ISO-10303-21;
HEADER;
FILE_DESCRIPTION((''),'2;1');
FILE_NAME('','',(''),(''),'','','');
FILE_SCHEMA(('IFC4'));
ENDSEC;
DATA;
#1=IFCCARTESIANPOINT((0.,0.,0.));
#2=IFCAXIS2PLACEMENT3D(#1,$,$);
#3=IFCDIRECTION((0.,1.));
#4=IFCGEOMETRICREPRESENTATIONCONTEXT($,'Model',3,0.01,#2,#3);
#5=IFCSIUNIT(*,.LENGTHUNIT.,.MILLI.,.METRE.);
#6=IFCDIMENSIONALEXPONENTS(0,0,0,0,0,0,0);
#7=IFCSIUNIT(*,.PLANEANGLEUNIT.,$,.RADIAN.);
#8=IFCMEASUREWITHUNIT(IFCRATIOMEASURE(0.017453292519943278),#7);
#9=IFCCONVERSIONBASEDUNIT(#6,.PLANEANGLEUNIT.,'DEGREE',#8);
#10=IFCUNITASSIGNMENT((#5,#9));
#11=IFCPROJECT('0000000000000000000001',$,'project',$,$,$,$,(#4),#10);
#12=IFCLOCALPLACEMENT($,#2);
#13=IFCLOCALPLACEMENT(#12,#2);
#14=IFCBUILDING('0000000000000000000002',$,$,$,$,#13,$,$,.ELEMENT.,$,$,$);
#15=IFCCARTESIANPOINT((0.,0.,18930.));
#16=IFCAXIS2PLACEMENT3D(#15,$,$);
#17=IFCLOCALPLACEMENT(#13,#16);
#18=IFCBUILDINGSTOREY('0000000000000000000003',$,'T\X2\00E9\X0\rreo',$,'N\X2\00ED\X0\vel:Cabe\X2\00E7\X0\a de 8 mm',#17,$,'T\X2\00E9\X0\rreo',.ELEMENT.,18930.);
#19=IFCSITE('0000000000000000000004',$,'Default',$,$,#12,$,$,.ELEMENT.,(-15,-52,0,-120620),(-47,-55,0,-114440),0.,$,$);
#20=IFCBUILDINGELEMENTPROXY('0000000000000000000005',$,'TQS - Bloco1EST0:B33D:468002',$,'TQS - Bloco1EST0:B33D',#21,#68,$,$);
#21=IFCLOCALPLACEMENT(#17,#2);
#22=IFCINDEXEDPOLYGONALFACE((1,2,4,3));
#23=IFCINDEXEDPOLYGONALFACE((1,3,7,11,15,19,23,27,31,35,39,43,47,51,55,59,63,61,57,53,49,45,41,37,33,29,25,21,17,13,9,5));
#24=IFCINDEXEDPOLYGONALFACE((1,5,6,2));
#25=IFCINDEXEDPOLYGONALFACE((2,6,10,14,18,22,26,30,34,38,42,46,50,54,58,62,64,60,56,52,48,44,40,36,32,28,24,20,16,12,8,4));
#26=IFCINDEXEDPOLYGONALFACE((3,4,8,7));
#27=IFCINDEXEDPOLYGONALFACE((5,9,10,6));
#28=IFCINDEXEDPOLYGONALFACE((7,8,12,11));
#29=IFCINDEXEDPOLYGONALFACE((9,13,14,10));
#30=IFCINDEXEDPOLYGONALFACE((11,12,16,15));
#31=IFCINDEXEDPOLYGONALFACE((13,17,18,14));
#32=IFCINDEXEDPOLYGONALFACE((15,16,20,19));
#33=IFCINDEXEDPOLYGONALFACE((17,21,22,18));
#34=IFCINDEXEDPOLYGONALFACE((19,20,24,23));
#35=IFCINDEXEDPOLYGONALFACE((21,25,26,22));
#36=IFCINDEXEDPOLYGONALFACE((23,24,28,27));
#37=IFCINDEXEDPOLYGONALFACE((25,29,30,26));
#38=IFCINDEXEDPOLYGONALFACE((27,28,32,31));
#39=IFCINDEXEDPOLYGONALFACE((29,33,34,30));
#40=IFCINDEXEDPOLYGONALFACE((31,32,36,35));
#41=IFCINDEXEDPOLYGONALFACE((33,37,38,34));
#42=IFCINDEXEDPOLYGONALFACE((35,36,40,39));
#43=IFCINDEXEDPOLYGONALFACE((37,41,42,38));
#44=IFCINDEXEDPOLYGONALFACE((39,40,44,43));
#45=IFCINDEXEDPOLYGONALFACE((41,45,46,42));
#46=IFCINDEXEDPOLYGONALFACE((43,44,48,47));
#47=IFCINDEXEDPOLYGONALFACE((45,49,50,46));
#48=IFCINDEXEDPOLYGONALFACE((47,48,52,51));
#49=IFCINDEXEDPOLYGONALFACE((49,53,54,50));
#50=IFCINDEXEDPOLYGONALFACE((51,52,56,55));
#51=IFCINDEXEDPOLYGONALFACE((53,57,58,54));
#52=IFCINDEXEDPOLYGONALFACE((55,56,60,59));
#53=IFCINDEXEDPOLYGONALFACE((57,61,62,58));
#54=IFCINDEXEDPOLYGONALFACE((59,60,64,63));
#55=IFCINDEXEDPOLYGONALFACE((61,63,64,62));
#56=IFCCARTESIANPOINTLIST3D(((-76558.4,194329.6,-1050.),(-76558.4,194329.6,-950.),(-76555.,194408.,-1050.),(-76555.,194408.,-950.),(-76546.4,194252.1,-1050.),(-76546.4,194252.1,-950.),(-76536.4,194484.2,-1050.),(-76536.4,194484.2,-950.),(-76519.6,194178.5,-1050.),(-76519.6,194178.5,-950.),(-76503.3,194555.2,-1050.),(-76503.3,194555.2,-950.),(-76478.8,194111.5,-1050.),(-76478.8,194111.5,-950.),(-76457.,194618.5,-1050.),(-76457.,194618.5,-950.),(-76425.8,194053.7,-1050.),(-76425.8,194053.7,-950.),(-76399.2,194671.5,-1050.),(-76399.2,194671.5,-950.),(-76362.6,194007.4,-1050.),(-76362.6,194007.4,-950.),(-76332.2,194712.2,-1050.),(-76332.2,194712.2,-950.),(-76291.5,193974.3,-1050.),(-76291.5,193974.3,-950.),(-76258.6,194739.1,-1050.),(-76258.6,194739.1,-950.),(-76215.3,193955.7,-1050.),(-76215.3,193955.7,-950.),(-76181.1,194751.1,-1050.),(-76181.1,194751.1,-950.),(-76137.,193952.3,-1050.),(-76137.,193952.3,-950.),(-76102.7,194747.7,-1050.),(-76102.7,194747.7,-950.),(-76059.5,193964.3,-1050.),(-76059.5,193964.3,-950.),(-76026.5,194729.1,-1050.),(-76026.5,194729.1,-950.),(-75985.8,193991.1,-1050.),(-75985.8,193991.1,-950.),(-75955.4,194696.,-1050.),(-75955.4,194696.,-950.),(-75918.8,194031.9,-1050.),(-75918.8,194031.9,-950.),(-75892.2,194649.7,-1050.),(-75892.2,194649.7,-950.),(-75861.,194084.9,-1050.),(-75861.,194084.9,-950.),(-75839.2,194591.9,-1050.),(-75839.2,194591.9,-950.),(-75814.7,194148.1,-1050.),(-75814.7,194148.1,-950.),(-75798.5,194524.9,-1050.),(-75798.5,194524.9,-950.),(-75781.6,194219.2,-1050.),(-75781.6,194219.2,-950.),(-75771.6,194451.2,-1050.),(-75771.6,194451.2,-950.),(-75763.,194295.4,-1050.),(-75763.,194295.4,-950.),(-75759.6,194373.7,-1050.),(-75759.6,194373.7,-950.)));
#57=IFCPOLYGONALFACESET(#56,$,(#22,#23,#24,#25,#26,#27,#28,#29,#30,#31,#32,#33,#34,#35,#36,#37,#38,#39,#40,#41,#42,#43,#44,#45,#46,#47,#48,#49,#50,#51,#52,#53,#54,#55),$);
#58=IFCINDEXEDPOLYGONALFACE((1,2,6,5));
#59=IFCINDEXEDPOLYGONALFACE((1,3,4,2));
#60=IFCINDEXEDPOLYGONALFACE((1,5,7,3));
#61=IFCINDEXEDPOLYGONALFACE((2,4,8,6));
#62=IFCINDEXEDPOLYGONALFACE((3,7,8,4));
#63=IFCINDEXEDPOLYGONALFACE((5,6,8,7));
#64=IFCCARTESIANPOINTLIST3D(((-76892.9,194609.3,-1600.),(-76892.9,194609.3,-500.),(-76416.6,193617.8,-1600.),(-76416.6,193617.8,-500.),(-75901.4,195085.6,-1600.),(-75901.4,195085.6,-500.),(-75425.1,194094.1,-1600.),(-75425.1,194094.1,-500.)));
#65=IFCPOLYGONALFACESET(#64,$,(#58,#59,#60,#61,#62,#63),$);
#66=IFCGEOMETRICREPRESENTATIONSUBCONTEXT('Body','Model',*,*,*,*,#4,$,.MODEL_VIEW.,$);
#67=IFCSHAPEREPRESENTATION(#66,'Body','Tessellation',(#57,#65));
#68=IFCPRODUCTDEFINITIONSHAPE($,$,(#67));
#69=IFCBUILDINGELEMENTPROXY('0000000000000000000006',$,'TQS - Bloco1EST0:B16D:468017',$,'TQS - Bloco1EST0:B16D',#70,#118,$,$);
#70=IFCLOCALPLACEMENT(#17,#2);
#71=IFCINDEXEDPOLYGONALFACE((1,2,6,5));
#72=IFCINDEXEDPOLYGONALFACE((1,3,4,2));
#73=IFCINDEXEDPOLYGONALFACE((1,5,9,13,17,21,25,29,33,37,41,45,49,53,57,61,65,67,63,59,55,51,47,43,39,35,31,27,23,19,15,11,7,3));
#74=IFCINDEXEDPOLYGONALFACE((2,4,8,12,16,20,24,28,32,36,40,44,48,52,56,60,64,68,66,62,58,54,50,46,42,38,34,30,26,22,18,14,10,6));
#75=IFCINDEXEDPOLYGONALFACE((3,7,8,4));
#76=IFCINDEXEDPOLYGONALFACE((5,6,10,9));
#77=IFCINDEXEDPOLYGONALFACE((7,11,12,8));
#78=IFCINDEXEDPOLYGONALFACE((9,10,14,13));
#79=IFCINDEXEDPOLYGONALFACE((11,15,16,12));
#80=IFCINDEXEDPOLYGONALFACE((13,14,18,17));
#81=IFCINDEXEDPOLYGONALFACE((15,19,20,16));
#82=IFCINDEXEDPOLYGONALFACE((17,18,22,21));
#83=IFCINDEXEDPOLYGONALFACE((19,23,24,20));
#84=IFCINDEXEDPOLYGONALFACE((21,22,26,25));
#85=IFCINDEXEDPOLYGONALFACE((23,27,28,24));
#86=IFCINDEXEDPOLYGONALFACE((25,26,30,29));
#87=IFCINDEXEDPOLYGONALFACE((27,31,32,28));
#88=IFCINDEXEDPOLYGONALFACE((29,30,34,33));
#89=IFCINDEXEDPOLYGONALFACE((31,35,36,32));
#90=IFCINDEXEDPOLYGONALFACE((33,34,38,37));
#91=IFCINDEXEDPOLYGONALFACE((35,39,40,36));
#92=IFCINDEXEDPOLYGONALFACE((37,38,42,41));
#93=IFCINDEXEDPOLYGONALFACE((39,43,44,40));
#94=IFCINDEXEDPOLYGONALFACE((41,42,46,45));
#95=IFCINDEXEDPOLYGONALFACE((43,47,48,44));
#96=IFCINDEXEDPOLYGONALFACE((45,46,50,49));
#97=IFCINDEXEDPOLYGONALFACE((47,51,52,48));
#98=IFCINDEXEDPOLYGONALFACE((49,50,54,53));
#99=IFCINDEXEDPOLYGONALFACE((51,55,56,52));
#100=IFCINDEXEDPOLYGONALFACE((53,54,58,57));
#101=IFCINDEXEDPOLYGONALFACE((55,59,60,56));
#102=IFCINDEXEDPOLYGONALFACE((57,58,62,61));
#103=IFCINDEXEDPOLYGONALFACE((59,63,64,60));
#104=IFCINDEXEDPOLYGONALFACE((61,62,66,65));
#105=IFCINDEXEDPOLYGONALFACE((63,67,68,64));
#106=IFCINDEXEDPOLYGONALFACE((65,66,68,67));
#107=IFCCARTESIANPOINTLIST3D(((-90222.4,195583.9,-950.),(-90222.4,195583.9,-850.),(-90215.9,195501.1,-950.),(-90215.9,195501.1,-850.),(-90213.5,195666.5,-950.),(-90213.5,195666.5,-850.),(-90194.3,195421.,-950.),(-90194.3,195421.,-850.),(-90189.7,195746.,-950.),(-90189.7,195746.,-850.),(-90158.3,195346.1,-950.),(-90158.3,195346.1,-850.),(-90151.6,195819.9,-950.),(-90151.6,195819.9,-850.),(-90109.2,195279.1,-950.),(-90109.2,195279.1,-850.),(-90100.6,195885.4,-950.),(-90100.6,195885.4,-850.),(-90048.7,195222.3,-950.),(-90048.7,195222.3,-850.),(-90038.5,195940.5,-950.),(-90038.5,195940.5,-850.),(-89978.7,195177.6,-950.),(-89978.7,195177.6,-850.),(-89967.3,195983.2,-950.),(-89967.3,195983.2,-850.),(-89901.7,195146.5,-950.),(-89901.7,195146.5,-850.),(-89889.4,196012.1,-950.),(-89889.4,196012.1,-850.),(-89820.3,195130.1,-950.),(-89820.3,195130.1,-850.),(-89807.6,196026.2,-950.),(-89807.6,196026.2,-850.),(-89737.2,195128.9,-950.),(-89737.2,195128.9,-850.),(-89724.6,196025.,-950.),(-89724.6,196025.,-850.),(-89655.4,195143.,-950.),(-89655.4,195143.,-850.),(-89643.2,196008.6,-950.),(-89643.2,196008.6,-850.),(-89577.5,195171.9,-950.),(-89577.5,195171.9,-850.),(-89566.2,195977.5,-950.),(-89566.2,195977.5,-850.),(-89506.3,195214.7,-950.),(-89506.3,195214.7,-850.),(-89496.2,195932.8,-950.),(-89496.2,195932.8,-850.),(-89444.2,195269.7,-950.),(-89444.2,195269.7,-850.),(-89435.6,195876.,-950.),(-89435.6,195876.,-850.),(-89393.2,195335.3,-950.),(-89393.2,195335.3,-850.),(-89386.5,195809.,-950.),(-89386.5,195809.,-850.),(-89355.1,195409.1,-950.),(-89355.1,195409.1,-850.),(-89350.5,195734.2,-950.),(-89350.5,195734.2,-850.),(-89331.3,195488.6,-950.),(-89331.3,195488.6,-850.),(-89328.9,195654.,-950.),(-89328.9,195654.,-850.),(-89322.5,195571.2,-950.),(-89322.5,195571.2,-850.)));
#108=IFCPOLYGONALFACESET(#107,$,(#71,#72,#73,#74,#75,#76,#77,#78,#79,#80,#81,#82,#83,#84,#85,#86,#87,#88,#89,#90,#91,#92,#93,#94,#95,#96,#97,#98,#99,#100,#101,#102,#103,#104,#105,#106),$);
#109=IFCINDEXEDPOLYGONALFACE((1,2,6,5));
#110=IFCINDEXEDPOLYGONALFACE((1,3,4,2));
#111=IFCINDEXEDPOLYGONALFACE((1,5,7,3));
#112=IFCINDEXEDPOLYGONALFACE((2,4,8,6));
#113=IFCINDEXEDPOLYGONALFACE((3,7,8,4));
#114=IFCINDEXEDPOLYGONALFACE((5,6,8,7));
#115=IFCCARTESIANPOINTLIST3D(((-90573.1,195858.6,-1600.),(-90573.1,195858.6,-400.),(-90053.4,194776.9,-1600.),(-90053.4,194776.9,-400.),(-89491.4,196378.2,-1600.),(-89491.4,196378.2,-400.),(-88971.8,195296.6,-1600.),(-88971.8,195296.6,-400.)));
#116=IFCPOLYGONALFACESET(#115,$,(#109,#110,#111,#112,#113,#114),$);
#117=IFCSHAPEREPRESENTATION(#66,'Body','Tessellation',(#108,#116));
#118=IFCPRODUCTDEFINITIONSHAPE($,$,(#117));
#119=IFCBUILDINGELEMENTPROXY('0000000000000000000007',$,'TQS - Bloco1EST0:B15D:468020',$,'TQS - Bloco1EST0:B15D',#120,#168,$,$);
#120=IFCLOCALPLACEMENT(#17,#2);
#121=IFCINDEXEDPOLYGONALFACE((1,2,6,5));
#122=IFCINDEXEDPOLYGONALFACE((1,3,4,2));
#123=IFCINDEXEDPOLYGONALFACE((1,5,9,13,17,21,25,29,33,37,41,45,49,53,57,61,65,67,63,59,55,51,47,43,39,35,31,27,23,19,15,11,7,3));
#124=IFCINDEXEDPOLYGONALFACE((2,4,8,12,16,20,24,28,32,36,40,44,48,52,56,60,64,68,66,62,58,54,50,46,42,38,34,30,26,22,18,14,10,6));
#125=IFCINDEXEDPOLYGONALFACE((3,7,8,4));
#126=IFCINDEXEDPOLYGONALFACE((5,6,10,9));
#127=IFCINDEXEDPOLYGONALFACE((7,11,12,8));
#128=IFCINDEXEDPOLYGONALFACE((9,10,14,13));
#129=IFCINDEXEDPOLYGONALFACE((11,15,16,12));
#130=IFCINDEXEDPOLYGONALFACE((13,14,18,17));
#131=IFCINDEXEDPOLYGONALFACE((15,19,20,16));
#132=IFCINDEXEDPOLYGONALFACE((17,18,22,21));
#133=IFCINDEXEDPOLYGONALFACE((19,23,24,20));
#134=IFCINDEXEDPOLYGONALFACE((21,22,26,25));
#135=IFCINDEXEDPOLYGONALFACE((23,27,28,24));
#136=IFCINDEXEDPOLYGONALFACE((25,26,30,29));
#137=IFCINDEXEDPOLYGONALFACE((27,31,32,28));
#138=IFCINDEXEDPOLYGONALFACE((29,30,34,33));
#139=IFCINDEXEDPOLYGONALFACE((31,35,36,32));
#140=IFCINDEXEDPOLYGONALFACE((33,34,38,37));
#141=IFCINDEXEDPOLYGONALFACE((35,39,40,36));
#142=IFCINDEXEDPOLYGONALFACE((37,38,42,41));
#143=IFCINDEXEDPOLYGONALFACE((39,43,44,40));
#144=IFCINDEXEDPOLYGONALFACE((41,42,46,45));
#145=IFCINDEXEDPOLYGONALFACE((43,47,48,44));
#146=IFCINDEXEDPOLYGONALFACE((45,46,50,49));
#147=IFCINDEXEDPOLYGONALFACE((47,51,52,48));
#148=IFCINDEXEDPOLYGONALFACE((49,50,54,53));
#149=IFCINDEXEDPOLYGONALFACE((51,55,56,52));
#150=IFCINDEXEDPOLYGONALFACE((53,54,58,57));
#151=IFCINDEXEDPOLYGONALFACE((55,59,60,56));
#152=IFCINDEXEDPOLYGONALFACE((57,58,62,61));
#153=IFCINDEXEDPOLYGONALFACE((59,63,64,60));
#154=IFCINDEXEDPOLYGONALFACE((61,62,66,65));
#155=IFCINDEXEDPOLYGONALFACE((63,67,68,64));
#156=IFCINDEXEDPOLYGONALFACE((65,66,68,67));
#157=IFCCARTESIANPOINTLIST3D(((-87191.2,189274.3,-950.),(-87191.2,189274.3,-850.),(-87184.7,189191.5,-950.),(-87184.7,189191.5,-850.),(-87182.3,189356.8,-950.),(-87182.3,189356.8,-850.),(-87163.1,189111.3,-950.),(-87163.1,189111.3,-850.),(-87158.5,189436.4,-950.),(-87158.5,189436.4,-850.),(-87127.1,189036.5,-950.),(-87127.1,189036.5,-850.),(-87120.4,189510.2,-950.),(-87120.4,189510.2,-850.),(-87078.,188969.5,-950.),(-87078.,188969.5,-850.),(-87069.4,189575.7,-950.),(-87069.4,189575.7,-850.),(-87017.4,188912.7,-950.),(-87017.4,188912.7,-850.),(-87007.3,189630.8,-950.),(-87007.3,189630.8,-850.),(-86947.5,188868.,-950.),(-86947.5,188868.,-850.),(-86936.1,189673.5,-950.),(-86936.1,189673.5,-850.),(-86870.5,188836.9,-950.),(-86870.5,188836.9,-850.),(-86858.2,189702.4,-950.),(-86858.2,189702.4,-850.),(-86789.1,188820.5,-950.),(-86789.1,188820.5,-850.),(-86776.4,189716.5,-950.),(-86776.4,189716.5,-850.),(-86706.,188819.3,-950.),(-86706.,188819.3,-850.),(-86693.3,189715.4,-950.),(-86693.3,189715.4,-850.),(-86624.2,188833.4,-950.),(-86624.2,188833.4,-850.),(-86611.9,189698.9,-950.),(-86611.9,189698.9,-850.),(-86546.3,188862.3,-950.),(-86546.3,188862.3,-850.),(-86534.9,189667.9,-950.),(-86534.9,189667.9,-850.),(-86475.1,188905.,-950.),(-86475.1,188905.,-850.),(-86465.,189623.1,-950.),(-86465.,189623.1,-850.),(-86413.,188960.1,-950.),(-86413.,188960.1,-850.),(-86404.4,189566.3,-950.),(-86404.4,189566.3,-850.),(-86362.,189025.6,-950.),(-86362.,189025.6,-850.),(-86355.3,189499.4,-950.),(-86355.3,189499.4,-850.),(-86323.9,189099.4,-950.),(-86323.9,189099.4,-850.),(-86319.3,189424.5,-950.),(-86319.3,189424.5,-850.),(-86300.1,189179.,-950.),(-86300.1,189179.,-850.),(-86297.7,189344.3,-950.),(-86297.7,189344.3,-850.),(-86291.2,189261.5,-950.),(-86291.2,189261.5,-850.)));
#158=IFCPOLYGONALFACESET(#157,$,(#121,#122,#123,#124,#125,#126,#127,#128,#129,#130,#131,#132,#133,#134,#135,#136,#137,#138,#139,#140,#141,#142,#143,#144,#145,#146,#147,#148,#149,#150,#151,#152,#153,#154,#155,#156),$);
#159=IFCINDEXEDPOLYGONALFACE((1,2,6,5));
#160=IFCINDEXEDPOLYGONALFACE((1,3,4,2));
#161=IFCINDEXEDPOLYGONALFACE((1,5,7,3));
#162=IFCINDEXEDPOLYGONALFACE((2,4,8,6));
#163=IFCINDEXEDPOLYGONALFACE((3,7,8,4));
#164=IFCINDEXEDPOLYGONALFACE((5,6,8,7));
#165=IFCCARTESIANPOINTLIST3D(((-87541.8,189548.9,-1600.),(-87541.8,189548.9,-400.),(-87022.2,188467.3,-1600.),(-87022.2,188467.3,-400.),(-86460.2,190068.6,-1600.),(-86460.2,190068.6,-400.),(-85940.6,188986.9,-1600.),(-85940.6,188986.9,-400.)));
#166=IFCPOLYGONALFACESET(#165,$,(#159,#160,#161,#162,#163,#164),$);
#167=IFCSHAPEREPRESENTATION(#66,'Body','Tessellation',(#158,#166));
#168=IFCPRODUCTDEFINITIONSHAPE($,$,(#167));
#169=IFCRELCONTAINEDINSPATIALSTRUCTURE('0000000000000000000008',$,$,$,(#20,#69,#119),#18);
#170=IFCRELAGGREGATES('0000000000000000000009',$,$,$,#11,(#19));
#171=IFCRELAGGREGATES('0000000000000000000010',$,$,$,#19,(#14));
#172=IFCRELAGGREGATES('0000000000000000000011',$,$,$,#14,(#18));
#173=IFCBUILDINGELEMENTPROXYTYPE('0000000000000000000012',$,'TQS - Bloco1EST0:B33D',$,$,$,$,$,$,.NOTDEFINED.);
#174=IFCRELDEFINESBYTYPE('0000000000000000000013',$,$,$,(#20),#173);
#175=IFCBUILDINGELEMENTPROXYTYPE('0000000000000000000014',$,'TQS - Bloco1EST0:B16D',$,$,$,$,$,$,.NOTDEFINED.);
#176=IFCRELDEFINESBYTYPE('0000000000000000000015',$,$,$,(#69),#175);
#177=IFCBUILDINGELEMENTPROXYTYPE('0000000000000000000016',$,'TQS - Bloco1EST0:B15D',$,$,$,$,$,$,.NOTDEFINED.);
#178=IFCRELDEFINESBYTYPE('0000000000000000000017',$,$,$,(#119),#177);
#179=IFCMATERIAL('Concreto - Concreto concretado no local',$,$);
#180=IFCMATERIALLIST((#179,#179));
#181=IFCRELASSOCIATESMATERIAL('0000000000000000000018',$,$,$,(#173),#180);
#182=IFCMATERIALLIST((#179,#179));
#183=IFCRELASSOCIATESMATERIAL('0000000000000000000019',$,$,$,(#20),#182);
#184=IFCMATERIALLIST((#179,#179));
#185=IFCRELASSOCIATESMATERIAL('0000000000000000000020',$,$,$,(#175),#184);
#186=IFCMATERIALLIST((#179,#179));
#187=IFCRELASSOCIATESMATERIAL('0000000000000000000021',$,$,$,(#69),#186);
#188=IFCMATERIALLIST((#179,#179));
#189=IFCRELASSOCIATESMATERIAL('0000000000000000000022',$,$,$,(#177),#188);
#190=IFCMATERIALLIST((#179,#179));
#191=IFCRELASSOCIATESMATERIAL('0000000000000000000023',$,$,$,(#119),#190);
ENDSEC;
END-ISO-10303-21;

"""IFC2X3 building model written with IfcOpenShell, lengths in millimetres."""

from ifc_helpers import new_model, entity, si_unit, converted_unit, direction, frame, frame_2d, origin, origin_2d_with_axis, place, context, subcontext, project, spatial, rectangle, circle, extrude, source, transform, mapped, material, material_list, type_object, type_shapes, element, save


model = new_model("IFC2X3")

# Units and contexts
model_context = context("Model", 3, precision=0.01, world=origin(), true_north=direction((0.0, 1.0)))
body_context = subcontext(model_context, "Body", "Model", "MODEL_VIEW")
ifc_project = project(units=[si_unit("LENGTHUNIT", "METRE", prefix="MILLI"), converted_unit("PLANEANGLEUNIT", "DEGREE", entity("IfcRatioMeasure", 0.017453292519943278), si_unit("PLANEANGLEUNIT", "RADIAN"), dimensions=[0, 0, 0, 0, 0, 0, 0])], contexts=[model_context])

# Site, building, storey
site_placement = place(None, origin())
site = spatial("IfcSite", under=ifc_project, at=site_placement, Name="Default", CompositionType="ELEMENT", RefLatitude=(-15, -52, 0, -120620), RefLongitude=(-47, -55, 0, -114440), RefElevation=0.0)
building_placement = place(site_placement, origin())
building = spatial("IfcBuilding", under=site, at=building_placement, CompositionType="ELEMENT")
storey_placement = place(building_placement, frame((0.0, 0.0, 18930.0)))
storey = spatial("IfcBuildingStorey", under=building, at=storey_placement, Name="Térreo", ObjectType="Nível:Cabeça de 8 mm", LongName="Térreo", CompositionType="ELEMENT", Elevation=18930.0)

# Building element proxies
ifc_material_1 = material(Name="Concreto - Concreto concretado no local")
ifc_material_list_1 = material_list([ifc_material_1, ifc_material_1])
ifc_material_list_2 = material_list([ifc_material_1, ifc_material_1])
building_element_proxy_type_1 = type_object("IfcBuildingElementProxyType", Name="TQS - Bloco1EST0:B33D", PredefinedType="NOTDEFINED", material=ifc_material_list_2)
shared_shape_1 = source(origin(), body_context, "Body", "SweptSolid", [
    extrude(circle(Radius=400.0, at=frame_2d((0.0, 0.0), x_axis=(1.0, 0.0))), frame((0.0, 0.0, -550.0)), (0.0, 0.0, 1.0), 100.0),
    extrude(rectangle(XDim=1100.0, YDim=1100.0, at=origin_2d_with_axis()), frame((0.0, 0.0, -1100.0), z_axis=(0.0, 0.0, 1.0), x_axis=(-1.0, 0.0, 0.0)), (0.0, 0.0, 1.0), 1100.0),
])
type_shapes(building_element_proxy_type_1, [shared_shape_1])
proxy_1_placement = place(storey_placement, frame((-76159.0, 194351.7, -500.0), z_axis=(0.0, 0.0, 1.0), x_axis=(-0.43303, 0.90138, 0.0)))
element("IfcBuildingElementProxy", 1, at=proxy_1_placement, inside=storey, type_object=building_element_proxy_type_1, material=ifc_material_list_1, Name="TQS - Bloco1EST0:B33D:468002", ObjectType="TQS - Bloco1EST0:B33D", context=body_context, shape_type="MappedRepresentation", body=[
    mapped(shared_shape_1, transform((0.0, 0.0, 0.0), scale=1.0)),
])
ifc_material_list_3 = material_list([ifc_material_1, ifc_material_1])
ifc_material_list_4 = material_list([ifc_material_1, ifc_material_1])
building_element_proxy_type_2 = type_object("IfcBuildingElementProxyType", Name="TQS - Bloco1EST0:B16D", PredefinedType="NOTDEFINED", material=ifc_material_list_4)
shared_shape_2 = source(origin(), body_context, "Body", "SweptSolid", [
    extrude(circle(Radius=450.0, at=frame_2d((0.0, 0.0), x_axis=(1.0, 0.0))), frame((0.0, 0.0, -550.0)), (0.0, 0.0, 1.0), 100.0),
    extrude(rectangle(XDim=1200.0, YDim=1200.0, at=origin_2d_with_axis()), frame((0.0, 0.0, -1200.0), z_axis=(0.0, 0.0, 1.0), x_axis=(-1.0, 0.0, 0.0)), (0.0, 0.0, 1.0), 1200.0),
])
type_shapes(building_element_proxy_type_2, [shared_shape_2])
proxy_2_placement = place(storey_placement, frame((-89772.4, 195577.6, -400.0), z_axis=(0.0, 0.0, 1.0), x_axis=(-0.43303, 0.90138, 0.0)))
element("IfcBuildingElementProxy", 2, at=proxy_2_placement, inside=storey, type_object=building_element_proxy_type_2, material=ifc_material_list_3, Name="TQS - Bloco1EST0:B16D:468017", ObjectType="TQS - Bloco1EST0:B16D", context=body_context, shape_type="MappedRepresentation", body=[
    mapped(shared_shape_2, transform((0.0, 0.0, 0.0), scale=1.0)),
])
ifc_material_list_5 = material_list([ifc_material_1, ifc_material_1])
ifc_material_list_6 = material_list([ifc_material_1, ifc_material_1])
building_element_proxy_type_3 = type_object("IfcBuildingElementProxyType", Name="TQS - Bloco1EST0:B15D", PredefinedType="NOTDEFINED", material=ifc_material_list_6)
shared_shape_3 = source(origin(), body_context, "Body", "SweptSolid", [
    extrude(circle(Radius=450.0, at=frame_2d((0.0, 0.0), x_axis=(1.0, 0.0))), frame((0.0, 0.0, -550.0)), (0.0, 0.0, 1.0), 100.0),
    extrude(rectangle(XDim=1200.0, YDim=1200.0, at=origin_2d_with_axis()), frame((0.0, 0.0, -1200.0), z_axis=(0.0, 0.0, 1.0), x_axis=(-1.0, 0.0, 0.0)), (0.0, 0.0, 1.0), 1200.0),
])
type_shapes(building_element_proxy_type_3, [shared_shape_3])
proxy_3_placement = place(storey_placement, frame((-86741.2, 189267.9, -400.0), z_axis=(0.0, 0.0, 1.0), x_axis=(-0.43303, 0.90138, 0.0)))
element("IfcBuildingElementProxy", 3, at=proxy_3_placement, inside=storey, type_object=building_element_proxy_type_3, material=ifc_material_list_5, Name="TQS - Bloco1EST0:B15D:468020", ObjectType="TQS - Bloco1EST0:B15D", context=body_context, shape_type="MappedRepresentation", body=[
    mapped(shared_shape_3, transform((0.0, 0.0, 0.0), scale=1.0)),
])

save(model, "model.ifc")
